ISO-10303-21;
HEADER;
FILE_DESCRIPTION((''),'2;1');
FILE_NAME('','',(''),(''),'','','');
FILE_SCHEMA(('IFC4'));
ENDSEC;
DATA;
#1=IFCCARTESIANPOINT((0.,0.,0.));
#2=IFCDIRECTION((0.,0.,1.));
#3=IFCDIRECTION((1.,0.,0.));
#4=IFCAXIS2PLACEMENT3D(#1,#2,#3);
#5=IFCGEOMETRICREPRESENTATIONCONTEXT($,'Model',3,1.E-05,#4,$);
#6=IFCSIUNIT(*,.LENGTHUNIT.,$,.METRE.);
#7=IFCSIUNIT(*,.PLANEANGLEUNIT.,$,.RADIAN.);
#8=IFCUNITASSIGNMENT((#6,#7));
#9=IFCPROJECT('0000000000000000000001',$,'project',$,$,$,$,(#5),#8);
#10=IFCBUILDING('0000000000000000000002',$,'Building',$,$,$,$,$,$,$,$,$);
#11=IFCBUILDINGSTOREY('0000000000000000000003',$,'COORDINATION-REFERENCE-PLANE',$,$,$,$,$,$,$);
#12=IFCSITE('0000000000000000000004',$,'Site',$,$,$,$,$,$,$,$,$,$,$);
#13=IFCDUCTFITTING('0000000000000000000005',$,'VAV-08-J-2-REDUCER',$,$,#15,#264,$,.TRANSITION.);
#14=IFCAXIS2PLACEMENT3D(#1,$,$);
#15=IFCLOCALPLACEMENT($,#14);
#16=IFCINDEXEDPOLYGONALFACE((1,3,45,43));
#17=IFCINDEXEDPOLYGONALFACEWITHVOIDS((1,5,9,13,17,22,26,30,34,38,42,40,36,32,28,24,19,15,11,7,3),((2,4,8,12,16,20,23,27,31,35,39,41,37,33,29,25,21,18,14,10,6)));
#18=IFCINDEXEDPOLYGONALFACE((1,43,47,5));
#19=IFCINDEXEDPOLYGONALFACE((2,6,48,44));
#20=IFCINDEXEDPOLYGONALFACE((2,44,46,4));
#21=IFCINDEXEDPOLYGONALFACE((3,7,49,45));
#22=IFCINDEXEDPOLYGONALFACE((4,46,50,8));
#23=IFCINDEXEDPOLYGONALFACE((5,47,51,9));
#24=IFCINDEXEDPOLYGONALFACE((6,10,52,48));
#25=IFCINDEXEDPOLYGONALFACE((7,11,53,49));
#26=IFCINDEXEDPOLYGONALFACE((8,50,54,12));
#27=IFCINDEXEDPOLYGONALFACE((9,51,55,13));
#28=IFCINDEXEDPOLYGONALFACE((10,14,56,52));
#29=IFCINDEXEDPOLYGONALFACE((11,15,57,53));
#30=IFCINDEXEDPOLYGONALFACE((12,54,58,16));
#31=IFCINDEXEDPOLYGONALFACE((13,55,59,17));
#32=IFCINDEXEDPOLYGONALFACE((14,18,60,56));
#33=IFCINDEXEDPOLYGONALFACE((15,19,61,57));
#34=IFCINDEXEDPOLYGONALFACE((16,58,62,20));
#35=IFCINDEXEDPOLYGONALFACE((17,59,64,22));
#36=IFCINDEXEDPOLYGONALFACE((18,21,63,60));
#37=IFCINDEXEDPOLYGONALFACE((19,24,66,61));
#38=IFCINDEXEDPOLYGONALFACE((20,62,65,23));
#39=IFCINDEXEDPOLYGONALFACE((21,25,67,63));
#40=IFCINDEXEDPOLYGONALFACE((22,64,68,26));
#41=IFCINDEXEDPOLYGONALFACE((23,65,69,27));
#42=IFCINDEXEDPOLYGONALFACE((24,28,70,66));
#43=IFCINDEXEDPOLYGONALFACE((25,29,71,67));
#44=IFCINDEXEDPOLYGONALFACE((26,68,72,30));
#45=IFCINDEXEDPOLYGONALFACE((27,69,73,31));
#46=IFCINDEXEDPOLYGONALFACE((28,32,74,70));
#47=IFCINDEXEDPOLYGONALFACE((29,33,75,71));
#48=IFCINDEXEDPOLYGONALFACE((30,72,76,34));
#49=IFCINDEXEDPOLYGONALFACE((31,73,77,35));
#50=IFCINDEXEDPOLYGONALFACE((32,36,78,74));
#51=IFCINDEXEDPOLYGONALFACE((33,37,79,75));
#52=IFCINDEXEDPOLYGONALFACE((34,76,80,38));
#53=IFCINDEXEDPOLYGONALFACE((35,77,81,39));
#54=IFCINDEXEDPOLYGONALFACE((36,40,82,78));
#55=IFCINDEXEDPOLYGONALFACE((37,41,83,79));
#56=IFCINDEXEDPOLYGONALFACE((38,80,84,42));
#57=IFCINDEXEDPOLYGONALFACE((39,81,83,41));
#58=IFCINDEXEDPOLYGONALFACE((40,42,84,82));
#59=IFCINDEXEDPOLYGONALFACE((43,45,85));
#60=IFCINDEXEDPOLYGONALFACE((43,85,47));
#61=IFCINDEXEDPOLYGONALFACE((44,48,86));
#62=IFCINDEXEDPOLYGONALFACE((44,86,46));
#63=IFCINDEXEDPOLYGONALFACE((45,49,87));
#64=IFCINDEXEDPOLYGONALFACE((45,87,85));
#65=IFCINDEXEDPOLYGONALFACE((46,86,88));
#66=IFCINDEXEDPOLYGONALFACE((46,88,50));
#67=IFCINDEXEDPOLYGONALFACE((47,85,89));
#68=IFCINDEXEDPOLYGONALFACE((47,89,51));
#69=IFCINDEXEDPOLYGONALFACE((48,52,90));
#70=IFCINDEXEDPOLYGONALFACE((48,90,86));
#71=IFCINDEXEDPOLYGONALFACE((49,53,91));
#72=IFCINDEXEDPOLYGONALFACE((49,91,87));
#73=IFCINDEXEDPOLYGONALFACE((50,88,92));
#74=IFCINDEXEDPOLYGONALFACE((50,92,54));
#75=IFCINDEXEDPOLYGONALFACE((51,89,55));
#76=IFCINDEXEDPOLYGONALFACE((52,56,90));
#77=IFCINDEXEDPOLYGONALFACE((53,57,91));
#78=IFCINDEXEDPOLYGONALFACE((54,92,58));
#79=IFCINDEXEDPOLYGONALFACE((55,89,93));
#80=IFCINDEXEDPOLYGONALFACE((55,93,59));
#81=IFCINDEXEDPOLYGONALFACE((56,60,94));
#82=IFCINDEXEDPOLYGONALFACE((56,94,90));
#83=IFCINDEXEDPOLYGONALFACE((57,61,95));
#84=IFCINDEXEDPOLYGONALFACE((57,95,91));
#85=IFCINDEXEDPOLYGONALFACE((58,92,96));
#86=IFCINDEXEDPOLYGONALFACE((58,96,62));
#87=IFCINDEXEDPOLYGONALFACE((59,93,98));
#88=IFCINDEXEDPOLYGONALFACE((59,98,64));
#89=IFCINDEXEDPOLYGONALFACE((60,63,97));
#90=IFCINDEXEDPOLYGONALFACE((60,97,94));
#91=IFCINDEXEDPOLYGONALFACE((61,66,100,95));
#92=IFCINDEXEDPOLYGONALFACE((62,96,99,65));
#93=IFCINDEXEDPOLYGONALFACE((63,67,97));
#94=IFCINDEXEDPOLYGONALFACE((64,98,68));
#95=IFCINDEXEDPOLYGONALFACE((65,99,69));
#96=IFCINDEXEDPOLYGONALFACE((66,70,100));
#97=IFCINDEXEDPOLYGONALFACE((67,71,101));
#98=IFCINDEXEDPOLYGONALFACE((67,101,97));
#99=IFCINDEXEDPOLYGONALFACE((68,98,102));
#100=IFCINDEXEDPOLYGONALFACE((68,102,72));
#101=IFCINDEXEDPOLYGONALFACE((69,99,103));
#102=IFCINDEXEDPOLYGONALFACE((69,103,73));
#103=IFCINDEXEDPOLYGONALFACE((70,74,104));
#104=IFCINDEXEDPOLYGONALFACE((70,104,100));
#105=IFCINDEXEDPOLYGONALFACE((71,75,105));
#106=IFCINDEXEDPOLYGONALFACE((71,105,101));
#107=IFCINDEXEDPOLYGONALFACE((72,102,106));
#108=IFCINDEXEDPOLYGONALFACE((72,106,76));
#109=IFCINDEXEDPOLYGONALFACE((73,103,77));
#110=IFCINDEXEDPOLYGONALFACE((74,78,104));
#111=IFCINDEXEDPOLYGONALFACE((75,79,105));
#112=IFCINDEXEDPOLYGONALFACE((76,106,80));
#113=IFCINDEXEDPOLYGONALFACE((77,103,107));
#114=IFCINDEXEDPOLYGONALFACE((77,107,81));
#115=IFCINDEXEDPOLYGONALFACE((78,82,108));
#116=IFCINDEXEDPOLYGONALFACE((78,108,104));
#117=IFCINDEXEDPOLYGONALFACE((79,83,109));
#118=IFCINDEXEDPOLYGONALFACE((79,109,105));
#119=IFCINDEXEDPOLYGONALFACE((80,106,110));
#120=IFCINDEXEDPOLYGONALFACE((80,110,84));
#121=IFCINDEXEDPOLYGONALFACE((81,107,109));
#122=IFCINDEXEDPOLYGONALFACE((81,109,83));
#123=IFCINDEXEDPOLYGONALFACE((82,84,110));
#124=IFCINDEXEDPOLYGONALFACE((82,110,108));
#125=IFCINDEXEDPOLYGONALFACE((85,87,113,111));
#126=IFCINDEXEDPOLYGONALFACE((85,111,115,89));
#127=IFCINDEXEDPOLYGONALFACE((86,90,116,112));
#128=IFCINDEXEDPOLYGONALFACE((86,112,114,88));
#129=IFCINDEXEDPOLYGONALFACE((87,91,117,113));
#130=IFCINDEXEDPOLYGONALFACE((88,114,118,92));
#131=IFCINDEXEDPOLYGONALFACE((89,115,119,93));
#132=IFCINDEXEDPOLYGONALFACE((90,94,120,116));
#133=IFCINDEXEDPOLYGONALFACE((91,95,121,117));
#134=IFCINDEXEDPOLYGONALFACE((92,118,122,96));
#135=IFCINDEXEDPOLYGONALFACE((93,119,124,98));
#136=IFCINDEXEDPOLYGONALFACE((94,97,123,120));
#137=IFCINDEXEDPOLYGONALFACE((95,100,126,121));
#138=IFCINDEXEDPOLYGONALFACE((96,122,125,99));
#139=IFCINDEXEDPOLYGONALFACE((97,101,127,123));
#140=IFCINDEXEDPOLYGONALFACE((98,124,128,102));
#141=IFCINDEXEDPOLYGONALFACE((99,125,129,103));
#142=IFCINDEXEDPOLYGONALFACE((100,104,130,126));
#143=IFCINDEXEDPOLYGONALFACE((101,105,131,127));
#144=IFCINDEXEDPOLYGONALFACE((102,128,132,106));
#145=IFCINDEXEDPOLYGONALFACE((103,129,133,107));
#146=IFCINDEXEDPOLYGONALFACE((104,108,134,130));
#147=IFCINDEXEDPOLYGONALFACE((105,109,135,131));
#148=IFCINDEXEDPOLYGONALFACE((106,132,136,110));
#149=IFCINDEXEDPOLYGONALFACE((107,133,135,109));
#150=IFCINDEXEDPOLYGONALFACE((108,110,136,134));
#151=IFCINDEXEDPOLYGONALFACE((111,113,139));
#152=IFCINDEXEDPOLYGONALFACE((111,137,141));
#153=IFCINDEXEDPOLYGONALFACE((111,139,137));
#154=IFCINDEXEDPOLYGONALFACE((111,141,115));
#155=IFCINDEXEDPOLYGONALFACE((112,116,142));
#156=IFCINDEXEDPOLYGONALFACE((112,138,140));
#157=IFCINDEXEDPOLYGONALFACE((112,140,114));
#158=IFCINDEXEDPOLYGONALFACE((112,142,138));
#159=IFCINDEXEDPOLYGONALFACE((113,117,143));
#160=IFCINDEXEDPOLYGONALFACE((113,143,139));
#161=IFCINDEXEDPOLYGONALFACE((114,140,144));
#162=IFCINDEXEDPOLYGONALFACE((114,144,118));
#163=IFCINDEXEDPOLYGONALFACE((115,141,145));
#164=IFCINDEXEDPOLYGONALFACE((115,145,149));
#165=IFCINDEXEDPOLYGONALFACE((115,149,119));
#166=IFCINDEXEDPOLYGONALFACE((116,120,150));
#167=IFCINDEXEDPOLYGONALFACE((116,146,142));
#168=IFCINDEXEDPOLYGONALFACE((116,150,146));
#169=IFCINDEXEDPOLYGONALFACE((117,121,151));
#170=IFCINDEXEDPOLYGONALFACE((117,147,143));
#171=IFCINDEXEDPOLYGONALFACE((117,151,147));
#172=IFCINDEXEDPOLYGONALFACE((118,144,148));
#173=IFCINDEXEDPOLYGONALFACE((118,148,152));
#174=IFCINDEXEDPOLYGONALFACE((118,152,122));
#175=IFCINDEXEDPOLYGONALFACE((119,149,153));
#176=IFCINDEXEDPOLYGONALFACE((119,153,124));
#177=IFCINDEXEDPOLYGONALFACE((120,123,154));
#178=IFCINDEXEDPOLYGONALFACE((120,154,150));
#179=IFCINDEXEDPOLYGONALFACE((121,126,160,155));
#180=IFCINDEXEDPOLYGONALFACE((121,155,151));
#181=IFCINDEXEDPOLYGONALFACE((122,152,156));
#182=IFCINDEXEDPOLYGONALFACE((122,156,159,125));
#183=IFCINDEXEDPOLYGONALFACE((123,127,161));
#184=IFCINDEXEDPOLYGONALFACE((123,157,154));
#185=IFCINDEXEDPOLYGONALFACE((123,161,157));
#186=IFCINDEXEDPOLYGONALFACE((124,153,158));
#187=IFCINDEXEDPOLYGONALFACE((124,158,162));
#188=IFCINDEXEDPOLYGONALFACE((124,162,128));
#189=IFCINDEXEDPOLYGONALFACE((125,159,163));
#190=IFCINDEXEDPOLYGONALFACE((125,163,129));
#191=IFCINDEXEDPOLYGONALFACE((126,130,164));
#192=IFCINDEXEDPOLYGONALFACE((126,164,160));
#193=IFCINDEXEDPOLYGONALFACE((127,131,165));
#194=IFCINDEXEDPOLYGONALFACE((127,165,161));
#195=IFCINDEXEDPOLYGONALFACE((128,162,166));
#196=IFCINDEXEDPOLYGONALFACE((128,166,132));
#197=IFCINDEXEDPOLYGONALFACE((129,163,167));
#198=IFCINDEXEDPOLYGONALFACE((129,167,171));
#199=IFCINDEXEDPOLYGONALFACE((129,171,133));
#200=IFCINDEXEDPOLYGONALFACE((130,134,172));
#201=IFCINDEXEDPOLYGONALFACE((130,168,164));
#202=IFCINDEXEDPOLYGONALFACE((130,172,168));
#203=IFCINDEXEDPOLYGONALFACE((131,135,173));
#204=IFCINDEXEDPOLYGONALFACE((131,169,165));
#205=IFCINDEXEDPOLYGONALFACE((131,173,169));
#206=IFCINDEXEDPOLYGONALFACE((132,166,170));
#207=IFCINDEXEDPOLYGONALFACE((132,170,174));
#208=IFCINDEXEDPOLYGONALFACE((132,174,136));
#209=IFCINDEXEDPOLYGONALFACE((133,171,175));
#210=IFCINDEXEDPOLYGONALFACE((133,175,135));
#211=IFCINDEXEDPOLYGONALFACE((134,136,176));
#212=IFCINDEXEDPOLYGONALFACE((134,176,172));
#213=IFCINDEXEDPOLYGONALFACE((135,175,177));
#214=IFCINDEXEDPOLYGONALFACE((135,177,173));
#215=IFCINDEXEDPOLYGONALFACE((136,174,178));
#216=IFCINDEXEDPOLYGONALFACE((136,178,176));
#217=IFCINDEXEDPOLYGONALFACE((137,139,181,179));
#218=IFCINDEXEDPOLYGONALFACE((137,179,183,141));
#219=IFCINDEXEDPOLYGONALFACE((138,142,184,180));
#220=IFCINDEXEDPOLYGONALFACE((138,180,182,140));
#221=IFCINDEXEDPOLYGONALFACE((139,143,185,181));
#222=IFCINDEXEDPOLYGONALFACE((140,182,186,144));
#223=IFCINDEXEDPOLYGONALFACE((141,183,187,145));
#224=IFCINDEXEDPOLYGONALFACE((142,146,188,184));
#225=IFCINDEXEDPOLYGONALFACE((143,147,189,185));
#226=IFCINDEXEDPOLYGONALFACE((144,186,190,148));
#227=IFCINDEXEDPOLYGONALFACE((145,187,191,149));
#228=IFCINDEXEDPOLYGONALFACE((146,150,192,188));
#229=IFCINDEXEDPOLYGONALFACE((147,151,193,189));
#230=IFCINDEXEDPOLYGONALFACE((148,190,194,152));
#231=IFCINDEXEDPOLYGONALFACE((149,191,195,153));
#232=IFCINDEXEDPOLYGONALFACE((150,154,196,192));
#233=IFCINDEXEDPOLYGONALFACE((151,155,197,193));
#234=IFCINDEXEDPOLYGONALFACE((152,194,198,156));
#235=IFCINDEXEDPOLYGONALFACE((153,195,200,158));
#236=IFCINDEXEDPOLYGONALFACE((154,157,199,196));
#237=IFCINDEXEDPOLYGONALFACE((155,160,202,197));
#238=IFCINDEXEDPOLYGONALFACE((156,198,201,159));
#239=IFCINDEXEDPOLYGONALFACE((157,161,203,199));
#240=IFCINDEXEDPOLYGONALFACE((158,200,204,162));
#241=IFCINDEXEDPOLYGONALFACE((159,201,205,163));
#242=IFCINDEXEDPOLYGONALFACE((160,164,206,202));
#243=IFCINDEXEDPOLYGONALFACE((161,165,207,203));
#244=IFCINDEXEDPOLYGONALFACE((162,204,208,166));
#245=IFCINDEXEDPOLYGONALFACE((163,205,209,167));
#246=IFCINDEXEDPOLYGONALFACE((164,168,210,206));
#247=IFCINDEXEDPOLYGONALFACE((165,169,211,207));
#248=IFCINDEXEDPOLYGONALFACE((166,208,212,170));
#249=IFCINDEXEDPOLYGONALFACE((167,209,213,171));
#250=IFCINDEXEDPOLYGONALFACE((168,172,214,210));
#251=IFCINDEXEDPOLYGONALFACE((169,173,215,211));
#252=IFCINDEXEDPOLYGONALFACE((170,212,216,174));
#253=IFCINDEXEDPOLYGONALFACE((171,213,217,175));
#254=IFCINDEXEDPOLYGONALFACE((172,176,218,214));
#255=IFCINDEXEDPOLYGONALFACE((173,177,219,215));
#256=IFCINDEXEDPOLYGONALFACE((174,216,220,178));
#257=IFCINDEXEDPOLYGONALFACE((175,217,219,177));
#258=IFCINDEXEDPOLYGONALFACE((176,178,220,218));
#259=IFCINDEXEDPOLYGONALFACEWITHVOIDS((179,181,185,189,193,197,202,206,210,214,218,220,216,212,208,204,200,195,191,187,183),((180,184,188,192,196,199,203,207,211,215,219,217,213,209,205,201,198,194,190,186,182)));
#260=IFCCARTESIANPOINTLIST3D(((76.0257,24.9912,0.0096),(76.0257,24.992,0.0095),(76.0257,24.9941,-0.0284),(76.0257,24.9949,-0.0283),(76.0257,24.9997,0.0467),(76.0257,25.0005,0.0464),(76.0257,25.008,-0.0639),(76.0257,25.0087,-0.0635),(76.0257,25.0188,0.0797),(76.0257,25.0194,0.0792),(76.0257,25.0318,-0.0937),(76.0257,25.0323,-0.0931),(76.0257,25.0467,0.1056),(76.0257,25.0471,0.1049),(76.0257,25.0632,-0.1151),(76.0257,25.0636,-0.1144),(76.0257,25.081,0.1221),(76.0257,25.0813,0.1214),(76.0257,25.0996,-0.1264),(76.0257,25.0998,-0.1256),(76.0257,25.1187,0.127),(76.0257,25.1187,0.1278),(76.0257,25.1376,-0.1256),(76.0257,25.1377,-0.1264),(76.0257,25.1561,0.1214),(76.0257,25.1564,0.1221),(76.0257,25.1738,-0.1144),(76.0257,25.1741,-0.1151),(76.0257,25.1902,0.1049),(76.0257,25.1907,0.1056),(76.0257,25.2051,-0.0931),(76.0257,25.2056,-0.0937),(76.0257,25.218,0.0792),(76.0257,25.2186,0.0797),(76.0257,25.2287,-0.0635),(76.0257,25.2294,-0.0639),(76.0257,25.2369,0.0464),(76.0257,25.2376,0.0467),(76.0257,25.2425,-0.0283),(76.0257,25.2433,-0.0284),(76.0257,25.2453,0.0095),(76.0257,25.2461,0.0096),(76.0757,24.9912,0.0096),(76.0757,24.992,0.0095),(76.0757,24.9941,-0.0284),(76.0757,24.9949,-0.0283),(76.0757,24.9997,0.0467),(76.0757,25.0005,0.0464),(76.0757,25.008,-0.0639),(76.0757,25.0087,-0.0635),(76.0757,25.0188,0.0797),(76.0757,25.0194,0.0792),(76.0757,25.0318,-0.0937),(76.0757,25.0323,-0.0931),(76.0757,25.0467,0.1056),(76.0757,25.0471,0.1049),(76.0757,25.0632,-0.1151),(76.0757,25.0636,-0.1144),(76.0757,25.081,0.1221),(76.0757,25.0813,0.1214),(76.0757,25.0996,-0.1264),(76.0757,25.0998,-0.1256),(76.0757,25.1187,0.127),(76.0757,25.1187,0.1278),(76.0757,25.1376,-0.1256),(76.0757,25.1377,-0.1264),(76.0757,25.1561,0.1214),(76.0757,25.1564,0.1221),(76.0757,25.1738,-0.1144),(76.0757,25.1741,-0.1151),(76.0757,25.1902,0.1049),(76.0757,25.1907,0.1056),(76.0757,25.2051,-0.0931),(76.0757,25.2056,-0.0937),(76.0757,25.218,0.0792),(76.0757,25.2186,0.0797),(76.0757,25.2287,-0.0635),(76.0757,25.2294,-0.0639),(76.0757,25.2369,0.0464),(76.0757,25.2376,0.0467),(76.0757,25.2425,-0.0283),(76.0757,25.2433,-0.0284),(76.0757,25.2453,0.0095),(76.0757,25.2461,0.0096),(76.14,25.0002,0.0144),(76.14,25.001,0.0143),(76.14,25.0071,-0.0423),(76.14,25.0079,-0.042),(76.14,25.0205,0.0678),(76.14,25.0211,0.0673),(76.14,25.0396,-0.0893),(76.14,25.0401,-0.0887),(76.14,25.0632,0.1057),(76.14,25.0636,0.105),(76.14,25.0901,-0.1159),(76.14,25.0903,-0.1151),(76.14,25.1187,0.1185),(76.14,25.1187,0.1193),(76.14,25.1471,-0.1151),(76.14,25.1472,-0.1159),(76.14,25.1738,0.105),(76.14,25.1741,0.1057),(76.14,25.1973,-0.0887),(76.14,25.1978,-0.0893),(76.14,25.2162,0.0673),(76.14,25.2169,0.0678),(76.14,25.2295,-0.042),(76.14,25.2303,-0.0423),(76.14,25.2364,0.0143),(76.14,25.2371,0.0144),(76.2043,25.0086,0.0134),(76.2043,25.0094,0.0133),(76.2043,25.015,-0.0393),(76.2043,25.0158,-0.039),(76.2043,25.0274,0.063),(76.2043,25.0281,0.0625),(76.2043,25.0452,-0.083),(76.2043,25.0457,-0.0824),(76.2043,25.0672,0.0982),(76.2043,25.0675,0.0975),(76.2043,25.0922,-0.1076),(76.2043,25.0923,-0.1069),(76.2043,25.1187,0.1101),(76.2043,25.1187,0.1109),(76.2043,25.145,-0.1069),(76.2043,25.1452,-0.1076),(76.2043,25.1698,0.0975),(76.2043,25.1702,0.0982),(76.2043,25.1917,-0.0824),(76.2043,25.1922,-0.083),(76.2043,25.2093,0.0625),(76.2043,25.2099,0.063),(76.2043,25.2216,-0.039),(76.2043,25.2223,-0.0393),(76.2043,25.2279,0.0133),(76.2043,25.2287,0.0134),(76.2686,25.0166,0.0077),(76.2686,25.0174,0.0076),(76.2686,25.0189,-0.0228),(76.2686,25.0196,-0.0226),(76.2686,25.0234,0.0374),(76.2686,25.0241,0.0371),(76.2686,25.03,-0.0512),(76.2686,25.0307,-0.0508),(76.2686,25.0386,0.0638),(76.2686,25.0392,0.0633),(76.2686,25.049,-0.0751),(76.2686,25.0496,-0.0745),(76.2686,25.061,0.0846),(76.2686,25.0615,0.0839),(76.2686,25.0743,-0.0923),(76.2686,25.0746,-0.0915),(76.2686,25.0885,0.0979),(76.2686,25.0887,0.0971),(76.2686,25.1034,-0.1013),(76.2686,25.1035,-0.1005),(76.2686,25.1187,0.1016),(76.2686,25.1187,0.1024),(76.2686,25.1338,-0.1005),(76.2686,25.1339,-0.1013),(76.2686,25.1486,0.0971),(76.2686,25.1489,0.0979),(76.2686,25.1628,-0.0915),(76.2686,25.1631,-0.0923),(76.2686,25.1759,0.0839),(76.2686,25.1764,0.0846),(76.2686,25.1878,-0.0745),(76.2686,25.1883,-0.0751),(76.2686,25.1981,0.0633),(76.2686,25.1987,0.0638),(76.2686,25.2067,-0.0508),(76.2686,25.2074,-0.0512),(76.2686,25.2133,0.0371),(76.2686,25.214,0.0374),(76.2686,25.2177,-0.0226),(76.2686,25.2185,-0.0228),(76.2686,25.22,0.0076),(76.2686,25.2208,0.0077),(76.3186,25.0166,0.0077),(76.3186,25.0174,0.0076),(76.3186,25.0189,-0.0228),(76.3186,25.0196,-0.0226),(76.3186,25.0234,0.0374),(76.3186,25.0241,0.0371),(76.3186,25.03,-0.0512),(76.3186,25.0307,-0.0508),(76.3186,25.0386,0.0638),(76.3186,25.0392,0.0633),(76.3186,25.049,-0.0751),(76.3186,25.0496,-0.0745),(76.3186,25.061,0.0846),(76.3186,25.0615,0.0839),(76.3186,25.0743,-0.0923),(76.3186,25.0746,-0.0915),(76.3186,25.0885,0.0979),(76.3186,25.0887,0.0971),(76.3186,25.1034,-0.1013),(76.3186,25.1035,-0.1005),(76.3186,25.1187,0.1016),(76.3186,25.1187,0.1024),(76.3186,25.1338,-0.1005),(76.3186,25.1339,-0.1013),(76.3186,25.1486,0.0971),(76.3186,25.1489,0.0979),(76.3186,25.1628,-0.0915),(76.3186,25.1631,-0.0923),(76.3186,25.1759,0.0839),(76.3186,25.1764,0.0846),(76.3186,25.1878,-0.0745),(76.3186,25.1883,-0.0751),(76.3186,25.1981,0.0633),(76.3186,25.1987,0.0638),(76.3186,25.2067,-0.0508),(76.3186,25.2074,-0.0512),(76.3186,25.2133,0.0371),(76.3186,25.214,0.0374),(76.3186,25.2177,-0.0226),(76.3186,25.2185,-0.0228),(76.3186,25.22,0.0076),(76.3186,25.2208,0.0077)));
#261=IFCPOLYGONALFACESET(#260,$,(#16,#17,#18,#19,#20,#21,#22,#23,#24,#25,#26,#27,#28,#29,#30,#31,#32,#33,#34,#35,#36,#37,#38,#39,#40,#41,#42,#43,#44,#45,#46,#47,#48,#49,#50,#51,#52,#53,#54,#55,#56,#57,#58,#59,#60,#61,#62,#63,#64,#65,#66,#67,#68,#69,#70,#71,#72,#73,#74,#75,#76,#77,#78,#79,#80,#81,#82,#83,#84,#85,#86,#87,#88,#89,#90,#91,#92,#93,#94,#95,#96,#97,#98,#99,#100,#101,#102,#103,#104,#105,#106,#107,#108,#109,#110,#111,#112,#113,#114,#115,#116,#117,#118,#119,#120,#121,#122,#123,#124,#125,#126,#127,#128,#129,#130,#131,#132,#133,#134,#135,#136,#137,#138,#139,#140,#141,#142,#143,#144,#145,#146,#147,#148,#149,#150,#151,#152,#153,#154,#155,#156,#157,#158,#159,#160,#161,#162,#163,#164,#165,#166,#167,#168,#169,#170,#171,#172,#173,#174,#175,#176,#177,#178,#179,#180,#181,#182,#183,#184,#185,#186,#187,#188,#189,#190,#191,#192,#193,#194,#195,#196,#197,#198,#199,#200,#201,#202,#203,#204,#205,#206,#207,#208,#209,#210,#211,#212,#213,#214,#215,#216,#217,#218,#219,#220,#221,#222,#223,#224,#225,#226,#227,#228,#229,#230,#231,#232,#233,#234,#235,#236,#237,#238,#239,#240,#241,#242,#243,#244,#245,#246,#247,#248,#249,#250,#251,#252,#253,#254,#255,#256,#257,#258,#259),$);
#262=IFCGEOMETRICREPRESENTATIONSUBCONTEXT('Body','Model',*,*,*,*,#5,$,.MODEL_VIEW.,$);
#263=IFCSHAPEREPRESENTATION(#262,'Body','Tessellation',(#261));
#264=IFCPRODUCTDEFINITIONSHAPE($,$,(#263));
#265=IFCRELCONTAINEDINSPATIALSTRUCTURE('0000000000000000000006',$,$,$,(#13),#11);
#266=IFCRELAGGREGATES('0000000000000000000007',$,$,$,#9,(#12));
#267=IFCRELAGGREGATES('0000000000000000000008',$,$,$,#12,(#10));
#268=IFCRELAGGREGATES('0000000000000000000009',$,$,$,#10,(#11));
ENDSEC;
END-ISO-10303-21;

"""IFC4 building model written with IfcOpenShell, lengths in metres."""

from ifc_helpers import new_model, entity, si_unit, frame, origin_with_axes, place, context, subcontext, project, spatial, element, save


model = new_model("IFC4")

# Units and contexts
model_context_1 = context("Model", 3, precision=1e-05, world=origin_with_axes())
body_context_1 = subcontext(model_context_1, "Body", "Model", "MODEL_VIEW")
ifc_project = project(units=[si_unit("LENGTHUNIT", "METRE"), si_unit("PLANEANGLEUNIT", "RADIAN")], contexts=[model_context_1])

# Site, building, storey
site = spatial("IfcSite", under=ifc_project, Name="Site")
building = spatial("IfcBuilding", under=site, Name="Building")
storey = spatial("IfcBuildingStorey", under=building, Name="COORDINATION-REFERENCE-PLANE")

# Duct fitting
for number, where, z_axis, x_axis, name in (
    (1, (76.0257, 25.1187, 0.0), (0.0, 1.0, 0.0), (0.0, 0.0, 1.0), "VAV-08-J-2-REDUCER"),
):
    element("IfcDuctFitting", number, at=place(None, frame(where, z_axis=z_axis, x_axis=x_axis)), inside=storey, Name=name, PredefinedType="TRANSITION", context=body_context_1, shape_type="SweptSolid", body=[
        entity("IfcRevolvedAreaSolid", entity("IfcArbitraryClosedProfileDef", "AREA", None, entity("IfcPolyline", [entity("IfcCartesianPoint", [0.1278, 0.0]), entity("IfcCartesianPoint", [0.1278, 0.05]), entity("IfcCartesianPoint", [0.1024, 0.2429]), entity("IfcCartesianPoint", [0.1024, 0.2929]), entity("IfcCartesianPoint", [0.1016, 0.2929]), entity("IfcCartesianPoint", [0.1016, 0.2429]), entity("IfcCartesianPoint", [0.127, 0.05]), entity("IfcCartesianPoint", [0.127, 0.0]), entity("IfcCartesianPoint", [0.1278, 0.0])])), entity("IfcAxis2Placement3D", entity("IfcCartesianPoint", [0.0, 0.0, 0.0])), entity("IfcAxis1Placement", entity("IfcCartesianPoint", [0.0, 0.0, 0.0]), entity("IfcDirection", [0.0, 1.0, 0.0])), 6.283185),
    ])

save(model, "model.ifc")
